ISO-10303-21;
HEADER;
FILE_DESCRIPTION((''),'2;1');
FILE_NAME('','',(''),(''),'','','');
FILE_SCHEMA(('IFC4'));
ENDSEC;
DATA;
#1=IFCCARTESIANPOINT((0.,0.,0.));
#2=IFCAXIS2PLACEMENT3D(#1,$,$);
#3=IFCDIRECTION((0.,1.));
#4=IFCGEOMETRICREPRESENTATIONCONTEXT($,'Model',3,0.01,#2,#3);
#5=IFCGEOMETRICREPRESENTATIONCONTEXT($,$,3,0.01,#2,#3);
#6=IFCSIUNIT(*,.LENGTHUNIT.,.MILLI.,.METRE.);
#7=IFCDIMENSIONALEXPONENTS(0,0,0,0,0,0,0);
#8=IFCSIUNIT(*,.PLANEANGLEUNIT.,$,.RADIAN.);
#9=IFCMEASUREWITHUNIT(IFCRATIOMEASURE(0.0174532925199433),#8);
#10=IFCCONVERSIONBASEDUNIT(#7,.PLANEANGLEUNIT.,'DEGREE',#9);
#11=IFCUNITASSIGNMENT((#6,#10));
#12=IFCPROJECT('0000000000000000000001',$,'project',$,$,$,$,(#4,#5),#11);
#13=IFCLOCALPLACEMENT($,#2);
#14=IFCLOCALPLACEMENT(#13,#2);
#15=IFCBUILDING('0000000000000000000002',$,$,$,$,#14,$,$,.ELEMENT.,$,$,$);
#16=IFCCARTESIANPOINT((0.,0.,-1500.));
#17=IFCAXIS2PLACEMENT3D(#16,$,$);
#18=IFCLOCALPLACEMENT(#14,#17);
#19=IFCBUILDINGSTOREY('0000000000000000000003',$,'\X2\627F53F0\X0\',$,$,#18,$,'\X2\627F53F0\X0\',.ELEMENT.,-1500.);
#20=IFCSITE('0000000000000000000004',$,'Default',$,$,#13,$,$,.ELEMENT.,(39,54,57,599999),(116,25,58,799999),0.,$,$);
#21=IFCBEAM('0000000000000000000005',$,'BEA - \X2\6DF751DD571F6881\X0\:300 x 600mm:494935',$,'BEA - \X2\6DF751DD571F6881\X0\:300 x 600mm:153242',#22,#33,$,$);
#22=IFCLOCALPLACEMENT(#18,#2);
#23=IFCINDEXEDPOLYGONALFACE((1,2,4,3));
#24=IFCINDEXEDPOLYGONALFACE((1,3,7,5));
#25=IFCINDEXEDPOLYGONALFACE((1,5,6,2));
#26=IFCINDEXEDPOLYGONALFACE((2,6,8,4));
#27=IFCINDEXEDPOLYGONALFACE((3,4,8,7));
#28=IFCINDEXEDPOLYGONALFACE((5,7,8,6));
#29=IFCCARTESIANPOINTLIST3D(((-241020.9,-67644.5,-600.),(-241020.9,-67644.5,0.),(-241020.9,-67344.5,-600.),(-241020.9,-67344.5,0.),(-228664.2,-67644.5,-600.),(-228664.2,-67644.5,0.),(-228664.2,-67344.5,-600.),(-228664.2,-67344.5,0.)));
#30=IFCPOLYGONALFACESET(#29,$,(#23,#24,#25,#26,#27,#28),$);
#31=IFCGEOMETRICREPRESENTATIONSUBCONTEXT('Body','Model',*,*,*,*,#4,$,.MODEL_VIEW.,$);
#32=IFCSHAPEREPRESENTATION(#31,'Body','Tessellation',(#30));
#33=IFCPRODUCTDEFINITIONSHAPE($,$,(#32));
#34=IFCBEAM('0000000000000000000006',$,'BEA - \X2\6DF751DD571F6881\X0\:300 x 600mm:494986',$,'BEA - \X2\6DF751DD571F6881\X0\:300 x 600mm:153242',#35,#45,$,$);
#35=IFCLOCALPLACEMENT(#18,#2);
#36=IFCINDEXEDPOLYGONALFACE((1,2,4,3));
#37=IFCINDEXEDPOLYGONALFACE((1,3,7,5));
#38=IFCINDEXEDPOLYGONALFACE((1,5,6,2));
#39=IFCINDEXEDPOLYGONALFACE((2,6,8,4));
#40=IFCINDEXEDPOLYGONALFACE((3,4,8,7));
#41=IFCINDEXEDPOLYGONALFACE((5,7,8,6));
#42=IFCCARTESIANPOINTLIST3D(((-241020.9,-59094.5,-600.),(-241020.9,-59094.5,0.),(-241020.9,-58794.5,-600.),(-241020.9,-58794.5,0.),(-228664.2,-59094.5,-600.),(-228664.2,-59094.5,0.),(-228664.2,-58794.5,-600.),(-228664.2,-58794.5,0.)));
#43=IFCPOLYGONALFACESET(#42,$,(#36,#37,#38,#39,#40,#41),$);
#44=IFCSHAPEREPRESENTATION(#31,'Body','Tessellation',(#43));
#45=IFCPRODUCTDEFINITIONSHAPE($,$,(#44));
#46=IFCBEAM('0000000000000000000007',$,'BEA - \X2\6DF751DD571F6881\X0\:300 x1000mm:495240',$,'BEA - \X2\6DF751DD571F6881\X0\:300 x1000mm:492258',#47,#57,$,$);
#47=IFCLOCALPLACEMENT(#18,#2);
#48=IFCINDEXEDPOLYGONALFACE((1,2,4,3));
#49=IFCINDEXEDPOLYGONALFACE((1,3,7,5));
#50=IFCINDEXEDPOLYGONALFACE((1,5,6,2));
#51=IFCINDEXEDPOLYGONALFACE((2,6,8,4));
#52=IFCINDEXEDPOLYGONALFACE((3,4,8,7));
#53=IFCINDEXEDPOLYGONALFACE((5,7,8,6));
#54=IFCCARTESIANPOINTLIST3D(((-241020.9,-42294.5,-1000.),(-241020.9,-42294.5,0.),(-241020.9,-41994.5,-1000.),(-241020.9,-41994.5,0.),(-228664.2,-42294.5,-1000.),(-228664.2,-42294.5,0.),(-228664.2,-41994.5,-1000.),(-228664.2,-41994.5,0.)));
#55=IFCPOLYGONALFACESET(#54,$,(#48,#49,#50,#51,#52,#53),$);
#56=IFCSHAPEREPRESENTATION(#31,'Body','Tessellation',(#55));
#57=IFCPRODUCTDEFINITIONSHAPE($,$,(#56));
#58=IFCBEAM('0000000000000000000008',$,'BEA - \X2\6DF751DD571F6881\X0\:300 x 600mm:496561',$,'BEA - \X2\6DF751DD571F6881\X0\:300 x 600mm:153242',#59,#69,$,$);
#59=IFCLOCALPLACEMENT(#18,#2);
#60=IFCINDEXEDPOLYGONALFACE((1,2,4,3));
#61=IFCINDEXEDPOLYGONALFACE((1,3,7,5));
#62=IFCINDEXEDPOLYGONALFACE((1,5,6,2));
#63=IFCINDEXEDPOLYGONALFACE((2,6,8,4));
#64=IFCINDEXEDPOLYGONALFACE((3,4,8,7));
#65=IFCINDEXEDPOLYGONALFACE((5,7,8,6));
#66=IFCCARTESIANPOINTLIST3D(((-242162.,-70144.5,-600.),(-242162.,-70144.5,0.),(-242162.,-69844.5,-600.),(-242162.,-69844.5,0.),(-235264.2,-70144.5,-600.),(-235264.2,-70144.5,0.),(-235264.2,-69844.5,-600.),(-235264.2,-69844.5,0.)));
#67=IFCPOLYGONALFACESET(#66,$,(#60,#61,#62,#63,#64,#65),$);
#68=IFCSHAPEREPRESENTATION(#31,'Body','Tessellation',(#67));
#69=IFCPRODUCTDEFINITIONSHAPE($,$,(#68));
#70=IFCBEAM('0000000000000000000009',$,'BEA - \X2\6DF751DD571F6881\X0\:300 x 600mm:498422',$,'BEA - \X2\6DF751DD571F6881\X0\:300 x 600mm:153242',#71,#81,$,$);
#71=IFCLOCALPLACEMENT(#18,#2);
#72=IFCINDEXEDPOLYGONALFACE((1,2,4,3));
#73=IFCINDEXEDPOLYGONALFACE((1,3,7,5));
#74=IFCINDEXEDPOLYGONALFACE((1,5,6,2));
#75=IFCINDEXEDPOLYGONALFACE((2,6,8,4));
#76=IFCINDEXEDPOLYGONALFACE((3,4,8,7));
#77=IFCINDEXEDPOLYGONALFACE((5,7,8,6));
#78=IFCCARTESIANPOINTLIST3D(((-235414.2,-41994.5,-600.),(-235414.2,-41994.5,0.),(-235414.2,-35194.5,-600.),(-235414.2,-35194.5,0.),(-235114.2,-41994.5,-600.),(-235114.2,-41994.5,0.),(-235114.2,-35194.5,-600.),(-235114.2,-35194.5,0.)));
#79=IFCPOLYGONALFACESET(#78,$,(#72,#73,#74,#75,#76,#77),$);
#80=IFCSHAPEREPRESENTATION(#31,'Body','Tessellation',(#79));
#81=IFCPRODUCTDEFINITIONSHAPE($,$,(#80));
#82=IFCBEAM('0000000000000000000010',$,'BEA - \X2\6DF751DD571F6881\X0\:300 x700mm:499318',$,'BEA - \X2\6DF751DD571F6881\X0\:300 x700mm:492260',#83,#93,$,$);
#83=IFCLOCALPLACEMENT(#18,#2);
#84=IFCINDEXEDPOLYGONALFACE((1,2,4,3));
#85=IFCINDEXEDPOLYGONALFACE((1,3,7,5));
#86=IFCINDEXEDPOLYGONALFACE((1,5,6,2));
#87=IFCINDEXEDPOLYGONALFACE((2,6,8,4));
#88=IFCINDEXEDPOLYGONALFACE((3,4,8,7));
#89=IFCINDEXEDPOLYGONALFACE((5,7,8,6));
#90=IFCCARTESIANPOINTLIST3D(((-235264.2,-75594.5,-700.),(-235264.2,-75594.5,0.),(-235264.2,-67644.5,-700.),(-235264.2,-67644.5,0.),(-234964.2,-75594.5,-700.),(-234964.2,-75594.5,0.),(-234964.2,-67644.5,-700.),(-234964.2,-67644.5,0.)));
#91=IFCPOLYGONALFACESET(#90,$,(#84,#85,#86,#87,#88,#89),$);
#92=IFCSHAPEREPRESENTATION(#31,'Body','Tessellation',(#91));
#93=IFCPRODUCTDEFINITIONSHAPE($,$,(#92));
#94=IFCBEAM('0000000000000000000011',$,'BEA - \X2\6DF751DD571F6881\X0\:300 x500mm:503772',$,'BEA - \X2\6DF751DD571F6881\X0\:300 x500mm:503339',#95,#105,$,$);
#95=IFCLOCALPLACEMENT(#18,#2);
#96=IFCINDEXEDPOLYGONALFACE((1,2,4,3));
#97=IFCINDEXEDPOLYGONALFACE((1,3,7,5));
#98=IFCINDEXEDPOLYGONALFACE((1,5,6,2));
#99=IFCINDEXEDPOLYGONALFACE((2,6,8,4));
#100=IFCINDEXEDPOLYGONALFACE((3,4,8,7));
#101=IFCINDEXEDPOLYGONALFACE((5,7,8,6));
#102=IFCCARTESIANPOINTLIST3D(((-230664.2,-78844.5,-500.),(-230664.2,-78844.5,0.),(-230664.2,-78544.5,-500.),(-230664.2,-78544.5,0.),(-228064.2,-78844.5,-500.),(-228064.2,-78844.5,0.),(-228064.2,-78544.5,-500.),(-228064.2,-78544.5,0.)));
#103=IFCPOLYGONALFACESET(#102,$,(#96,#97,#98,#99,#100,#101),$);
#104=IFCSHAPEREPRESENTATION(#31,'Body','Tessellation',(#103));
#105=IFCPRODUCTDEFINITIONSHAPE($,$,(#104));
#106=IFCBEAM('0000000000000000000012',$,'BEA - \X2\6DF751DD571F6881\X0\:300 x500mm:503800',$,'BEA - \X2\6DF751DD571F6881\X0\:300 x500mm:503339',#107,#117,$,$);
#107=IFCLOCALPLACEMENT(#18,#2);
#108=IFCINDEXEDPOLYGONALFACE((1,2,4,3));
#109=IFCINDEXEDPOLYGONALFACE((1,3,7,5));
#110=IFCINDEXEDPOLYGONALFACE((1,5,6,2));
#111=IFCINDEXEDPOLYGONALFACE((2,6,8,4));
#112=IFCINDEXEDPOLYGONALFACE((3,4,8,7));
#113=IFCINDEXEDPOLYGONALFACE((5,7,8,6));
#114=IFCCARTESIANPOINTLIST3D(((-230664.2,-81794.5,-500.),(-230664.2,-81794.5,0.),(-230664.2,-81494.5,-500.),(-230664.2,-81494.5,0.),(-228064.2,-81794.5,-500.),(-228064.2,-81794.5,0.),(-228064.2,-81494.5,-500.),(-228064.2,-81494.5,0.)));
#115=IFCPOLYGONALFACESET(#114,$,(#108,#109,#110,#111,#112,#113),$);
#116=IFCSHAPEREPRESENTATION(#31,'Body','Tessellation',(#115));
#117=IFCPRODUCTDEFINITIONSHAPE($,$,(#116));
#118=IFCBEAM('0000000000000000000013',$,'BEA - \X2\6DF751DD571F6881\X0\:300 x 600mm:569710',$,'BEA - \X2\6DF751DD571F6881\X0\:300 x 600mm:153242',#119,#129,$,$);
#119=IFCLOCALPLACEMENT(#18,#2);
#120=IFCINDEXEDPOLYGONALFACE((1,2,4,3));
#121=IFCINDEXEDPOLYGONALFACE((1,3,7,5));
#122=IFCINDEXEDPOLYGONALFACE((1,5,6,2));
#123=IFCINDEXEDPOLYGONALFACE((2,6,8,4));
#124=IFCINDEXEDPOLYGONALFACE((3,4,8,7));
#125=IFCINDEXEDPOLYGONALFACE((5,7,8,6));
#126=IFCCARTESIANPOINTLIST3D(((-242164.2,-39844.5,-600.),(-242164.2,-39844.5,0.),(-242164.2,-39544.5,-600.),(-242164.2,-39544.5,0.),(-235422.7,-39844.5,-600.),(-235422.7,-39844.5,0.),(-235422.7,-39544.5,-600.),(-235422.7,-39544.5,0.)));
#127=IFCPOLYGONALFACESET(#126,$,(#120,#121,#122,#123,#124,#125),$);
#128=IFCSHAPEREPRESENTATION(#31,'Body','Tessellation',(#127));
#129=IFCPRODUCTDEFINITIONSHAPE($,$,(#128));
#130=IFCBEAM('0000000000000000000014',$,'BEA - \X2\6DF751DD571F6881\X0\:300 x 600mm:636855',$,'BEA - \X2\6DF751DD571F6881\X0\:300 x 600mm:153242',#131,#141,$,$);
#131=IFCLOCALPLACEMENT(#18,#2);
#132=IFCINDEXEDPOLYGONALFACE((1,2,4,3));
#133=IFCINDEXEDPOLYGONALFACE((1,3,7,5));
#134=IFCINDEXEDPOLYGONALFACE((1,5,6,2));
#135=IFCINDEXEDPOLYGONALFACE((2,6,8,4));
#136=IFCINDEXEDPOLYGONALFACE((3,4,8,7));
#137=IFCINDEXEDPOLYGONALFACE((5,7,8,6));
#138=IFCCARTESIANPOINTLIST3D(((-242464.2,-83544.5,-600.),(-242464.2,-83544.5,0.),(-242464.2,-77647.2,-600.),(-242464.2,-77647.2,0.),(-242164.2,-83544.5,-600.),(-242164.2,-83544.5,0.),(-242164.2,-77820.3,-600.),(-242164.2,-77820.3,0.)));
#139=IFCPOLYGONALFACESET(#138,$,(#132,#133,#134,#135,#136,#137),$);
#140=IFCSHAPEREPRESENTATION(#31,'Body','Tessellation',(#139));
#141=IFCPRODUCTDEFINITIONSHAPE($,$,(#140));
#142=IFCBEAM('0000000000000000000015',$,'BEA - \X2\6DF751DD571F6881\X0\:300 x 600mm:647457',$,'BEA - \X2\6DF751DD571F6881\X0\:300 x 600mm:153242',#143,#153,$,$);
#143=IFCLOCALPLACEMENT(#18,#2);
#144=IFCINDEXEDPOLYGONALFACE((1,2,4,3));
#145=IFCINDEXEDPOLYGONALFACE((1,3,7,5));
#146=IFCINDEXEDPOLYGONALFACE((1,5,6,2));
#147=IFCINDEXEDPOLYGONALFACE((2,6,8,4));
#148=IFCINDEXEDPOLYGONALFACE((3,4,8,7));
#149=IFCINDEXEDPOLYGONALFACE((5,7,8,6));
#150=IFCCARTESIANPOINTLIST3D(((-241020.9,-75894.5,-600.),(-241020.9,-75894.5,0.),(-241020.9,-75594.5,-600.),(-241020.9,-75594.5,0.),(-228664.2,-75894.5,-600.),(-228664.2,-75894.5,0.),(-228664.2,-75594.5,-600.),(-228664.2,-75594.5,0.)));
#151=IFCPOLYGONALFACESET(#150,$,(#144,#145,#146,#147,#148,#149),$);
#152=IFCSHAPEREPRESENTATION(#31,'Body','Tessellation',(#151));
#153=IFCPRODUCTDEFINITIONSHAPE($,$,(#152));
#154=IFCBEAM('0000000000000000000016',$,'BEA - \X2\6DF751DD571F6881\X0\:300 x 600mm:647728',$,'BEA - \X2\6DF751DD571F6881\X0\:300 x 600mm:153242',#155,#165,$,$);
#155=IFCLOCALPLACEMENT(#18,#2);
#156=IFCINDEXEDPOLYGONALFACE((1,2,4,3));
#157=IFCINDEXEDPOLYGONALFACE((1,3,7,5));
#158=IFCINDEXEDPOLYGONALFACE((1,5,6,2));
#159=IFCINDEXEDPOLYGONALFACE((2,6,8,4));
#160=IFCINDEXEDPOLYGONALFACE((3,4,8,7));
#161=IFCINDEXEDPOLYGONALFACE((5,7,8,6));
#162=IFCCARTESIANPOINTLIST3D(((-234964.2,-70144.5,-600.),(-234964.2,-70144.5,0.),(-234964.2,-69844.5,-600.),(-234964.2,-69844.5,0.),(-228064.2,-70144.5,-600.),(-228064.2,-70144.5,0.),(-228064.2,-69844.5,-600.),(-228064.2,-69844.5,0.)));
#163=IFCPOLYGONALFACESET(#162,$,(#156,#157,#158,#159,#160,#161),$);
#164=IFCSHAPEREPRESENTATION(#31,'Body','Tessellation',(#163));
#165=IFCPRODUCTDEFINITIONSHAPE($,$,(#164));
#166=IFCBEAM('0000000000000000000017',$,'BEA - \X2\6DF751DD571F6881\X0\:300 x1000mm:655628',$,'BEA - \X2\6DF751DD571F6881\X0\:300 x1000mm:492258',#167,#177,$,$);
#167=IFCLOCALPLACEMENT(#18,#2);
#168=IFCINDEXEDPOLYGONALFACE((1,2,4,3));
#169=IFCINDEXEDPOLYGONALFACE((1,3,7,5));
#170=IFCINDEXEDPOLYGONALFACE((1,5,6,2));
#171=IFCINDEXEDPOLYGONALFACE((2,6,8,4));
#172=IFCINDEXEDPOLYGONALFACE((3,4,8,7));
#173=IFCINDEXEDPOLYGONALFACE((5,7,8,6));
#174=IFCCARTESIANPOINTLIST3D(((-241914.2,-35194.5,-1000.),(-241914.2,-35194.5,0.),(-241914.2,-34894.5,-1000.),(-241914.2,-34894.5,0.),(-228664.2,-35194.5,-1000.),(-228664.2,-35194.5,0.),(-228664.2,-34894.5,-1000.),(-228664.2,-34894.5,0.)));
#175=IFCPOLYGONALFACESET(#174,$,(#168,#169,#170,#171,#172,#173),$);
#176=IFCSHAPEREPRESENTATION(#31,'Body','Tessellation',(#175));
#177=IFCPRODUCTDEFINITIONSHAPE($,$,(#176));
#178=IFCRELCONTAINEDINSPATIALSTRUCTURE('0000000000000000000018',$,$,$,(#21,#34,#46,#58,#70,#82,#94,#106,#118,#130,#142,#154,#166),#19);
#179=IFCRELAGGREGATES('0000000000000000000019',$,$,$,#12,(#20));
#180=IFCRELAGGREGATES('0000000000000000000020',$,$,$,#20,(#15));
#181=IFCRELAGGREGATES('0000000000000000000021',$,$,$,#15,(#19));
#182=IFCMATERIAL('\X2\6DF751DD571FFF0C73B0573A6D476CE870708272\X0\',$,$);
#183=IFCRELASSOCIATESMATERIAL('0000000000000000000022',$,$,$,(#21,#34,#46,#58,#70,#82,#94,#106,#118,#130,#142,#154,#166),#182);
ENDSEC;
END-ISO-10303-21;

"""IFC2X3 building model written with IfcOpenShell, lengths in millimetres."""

from ifc_helpers import new_model, entity, si_unit, converted_unit, direction, frame, frame_2d, origin, origin_2d_with_axis, place, context, subcontext, project, spatial, rectangle, extrude, clip, halfspace, material, element, save


model = new_model("IFC2X3")

# Units and contexts
model_context = context("Model", 3, precision=0.01, world=origin(), true_north=direction((0.0, 1.0)))
context_of_model = context(None, 3, precision=0.01, world=origin(), true_north=direction((0.0, 1.0)))
body_context = subcontext(model_context, "Body", "Model", "MODEL_VIEW")
ifc_project = project(units=[si_unit("LENGTHUNIT", "METRE", prefix="MILLI"), converted_unit("PLANEANGLEUNIT", "DEGREE", entity("IfcRatioMeasure", 0.0174532925199433), si_unit("PLANEANGLEUNIT", "RADIAN"), dimensions=[0, 0, 0, 0, 0, 0, 0])], contexts=[model_context, context_of_model])

# Site, building, storey
site_placement = place(None, origin())
site = spatial("IfcSite", under=ifc_project, at=site_placement, Name="Default", CompositionType="ELEMENT", RefLatitude=(39, 54, 57, 599999), RefLongitude=(116, 25, 58, 799999), RefElevation=0.0)
building_placement = place(site_placement, origin())
building = spatial("IfcBuilding", under=site, at=building_placement, CompositionType="ELEMENT")
storey_placement = place(building_placement, frame((0.0, 0.0, -1500.0)))
storey = spatial("IfcBuildingStorey", under=building, at=storey_placement, Name="承台", LongName="承台", CompositionType="ELEMENT", Elevation=-1500.0)

# Beams
ifc_material_1 = material(Name="混凝土，现场浇注灰色")
for number, where, name in (
    (1, (-241020.9, -67494.5, 0.0), "BEA - 混凝土梁:300 x 600mm:494935"),
    (2, (-241020.9, -58944.5, 0.0), "BEA - 混凝土梁:300 x 600mm:494986"),
):
    element("IfcBeam", number, at=place(storey_placement, frame(where)), inside=storey, material=ifc_material_1, Name=name, ObjectType="BEA - 混凝土梁:300 x 600mm:153242", context=body_context, shape_type="SweptSolid", body=[
        extrude(rectangle(XDim=600.0, YDim=300.0, at=frame_2d((0.0, 0.0), x_axis=(1.0, 0.0))), frame((0.0, 0.0, -300.0), z_axis=(1.0, 0.0, 0.0), x_axis=(0.0, 0.0, -1.0)), (0.0, 0.0, 1.0), 12356.7),
    ])
beam_1_placement = place(storey_placement, frame((-241020.9, -42144.5, 0.0)))
element("IfcBeam", 3, at=beam_1_placement, inside=storey, material=ifc_material_1, Name="BEA - 混凝土梁:300 x1000mm:495240", ObjectType="BEA - 混凝土梁:300 x1000mm:492258", context=body_context, shape_type="SweptSolid", body=[
    extrude(rectangle(XDim=1000.0, YDim=300.0, at=frame_2d((0.0, 0.0), x_axis=(1.0, 0.0))), frame((0.0, 0.0, -500.0), z_axis=(1.0, 0.0, 0.0), x_axis=(0.0, 0.0, -1.0)), (0.0, 0.0, 1.0), 12356.7),
])
beam_2_placement = place(storey_placement, frame((-242162.0, -69994.5, 0.0)))
element("IfcBeam", 4, at=beam_2_placement, inside=storey, material=ifc_material_1, Name="BEA - 混凝土梁:300 x 600mm:496561", ObjectType="BEA - 混凝土梁:300 x 600mm:153242", context=body_context, shape_type="SweptSolid", body=[
    extrude(rectangle(XDim=600.0, YDim=300.0, at=frame_2d((0.0, 0.0), x_axis=(1.0, 0.0))), frame((0.0, 0.0, -300.0), z_axis=(1.0, 0.0, 0.0), x_axis=(0.0, 0.0, -1.0)), (0.0, 0.0, 1.0), 6897.8),
])
beam_3_placement = place(storey_placement, frame((-235264.2, -35194.5, 0.0), z_axis=(0.0, 0.0, 1.0), x_axis=(0.0, -1.0, 0.0)))
element("IfcBeam", 5, at=beam_3_placement, inside=storey, material=ifc_material_1, Name="BEA - 混凝土梁:300 x 600mm:498422", ObjectType="BEA - 混凝土梁:300 x 600mm:153242", context=body_context, shape_type="SweptSolid", body=[
    extrude(rectangle(XDim=600.0, YDim=300.0, at=origin_2d_with_axis()), frame((0.0, 0.0, -300.0), z_axis=(1.0, 0.0, 0.0), x_axis=(0.0, 0.0, -1.0)), (0.0, 0.0, 1.0), 6800.0),
])
beam_4_placement = place(storey_placement, frame((-235114.2, -67644.5, 0.0), z_axis=(0.0, 0.0, 1.0), x_axis=(0.0, -1.0, 0.0)))
element("IfcBeam", 6, at=beam_4_placement, inside=storey, material=ifc_material_1, Name="BEA - 混凝土梁:300 x700mm:499318", ObjectType="BEA - 混凝土梁:300 x700mm:492260", context=body_context, shape_type="SweptSolid", body=[
    extrude(rectangle(XDim=700.0, YDim=300.0, at=frame_2d((0.0, 0.0), x_axis=(1.0, 0.0))), frame((0.0, 0.0, -350.0), z_axis=(1.0, 0.0, 0.0), x_axis=(0.0, 0.0, -1.0)), (0.0, 0.0, 1.0), 7950.0),
])
for number, where, name in (
    (7, (-230664.2, -78694.5, 0.0), "BEA - 混凝土梁:300 x500mm:503772"),
    (8, (-230664.2, -81644.5, 0.0), "BEA - 混凝土梁:300 x500mm:503800"),
):
    element("IfcBeam", number, at=place(storey_placement, frame(where)), inside=storey, material=ifc_material_1, Name=name, ObjectType="BEA - 混凝土梁:300 x500mm:503339", context=body_context, shape_type="SweptSolid", body=[
        extrude(rectangle(XDim=500.0, YDim=300.0, at=frame_2d((0.0, 0.0), x_axis=(1.0, 0.0))), frame((0.0, 0.0, -250.0), z_axis=(1.0, 0.0, 0.0), x_axis=(0.0, 0.0, -1.0)), (0.0, 0.0, 1.0), 2600.0),
    ])
beam_5_placement = place(storey_placement, frame((-242164.2, -39694.5, 0.0)))
element("IfcBeam", 9, at=beam_5_placement, inside=storey, material=ifc_material_1, Name="BEA - 混凝土梁:300 x 600mm:569710", ObjectType="BEA - 混凝土梁:300 x 600mm:153242", context=body_context, shape_type="SweptSolid", body=[
    extrude(rectangle(XDim=600.0, YDim=300.0, at=frame_2d((0.0, 0.0), x_axis=(1.0, 0.0))), frame((0.0, 0.0, -300.0), z_axis=(1.0, 0.0, 0.0), x_axis=(0.0, 0.0, -1.0)), (0.0, 0.0, 1.0), 6741.5),
])
beam_6_placement = place(storey_placement, frame((-242314.2, -83544.5, 0.0), z_axis=(0.0, 0.0, 1.0), x_axis=(0.0, 1.0, 0.0)))
element("IfcBeam", 10, at=beam_6_placement, inside=storey, material=ifc_material_1, Name="BEA - 混凝土梁:300 x 600mm:636855", ObjectType="BEA - 混凝土梁:300 x 600mm:153242", context=body_context, shape_type="Clipping", body=[
    clip(extrude(rectangle(XDim=600.0, YDim=300.0, at=frame_2d((0.0, 0.0), x_axis=(1.0, 0.0))), frame((0.0, 0.0, -300.0), z_axis=(1.0, 0.0, 0.0), x_axis=(0.0, 0.0, -1.0)), (0.0, 0.0, 1.0), 5897.3), halfspace(frame((7188.0, 2386.7, 0.0), z_axis=(0.866125, -0.499827, 0.0), x_axis=(-0.499827, -0.866125, 0.0)), False)),
])
beam_7_placement = place(storey_placement, frame((-241020.9, -75744.5, 0.0)))
element("IfcBeam", 11, at=beam_7_placement, inside=storey, material=ifc_material_1, Name="BEA - 混凝土梁:300 x 600mm:647457", ObjectType="BEA - 混凝土梁:300 x 600mm:153242", context=body_context, shape_type="SweptSolid", body=[
    extrude(rectangle(XDim=600.0, YDim=300.0, at=frame_2d((0.0, 0.0), x_axis=(1.0, 0.0))), frame((0.0, 0.0, -300.0), z_axis=(1.0, 0.0, 0.0), x_axis=(0.0, 0.0, -1.0)), (0.0, 0.0, 1.0), 12356.7),
])
beam_8_placement = place(storey_placement, frame((-234964.2, -69994.5, 0.0)))
element("IfcBeam", 12, at=beam_8_placement, inside=storey, material=ifc_material_1, Name="BEA - 混凝土梁:300 x 600mm:647728", ObjectType="BEA - 混凝土梁:300 x 600mm:153242", context=body_context, shape_type="SweptSolid", body=[
    extrude(rectangle(XDim=600.0, YDim=300.0, at=frame_2d((0.0, 0.0), x_axis=(1.0, 0.0))), frame((0.0, 0.0, -300.0), z_axis=(1.0, 0.0, 0.0), x_axis=(0.0, 0.0, -1.0)), (0.0, 0.0, 1.0), 6900.0),
])
beam_9_placement = place(storey_placement, frame((-241914.2, -35044.5, 0.0)))
element("IfcBeam", 13, at=beam_9_placement, inside=storey, material=ifc_material_1, Name="BEA - 混凝土梁:300 x1000mm:655628", ObjectType="BEA - 混凝土梁:300 x1000mm:492258", context=body_context, shape_type="SweptSolid", body=[
    extrude(rectangle(XDim=1000.0, YDim=300.0, at=frame_2d((0.0, 0.0), x_axis=(1.0, 0.0))), frame((0.0, 0.0, -500.0), z_axis=(1.0, 0.0, 0.0), x_axis=(0.0, 0.0, -1.0)), (0.0, 0.0, 1.0), 13250.0),
])

save(model, "model.ifc")
